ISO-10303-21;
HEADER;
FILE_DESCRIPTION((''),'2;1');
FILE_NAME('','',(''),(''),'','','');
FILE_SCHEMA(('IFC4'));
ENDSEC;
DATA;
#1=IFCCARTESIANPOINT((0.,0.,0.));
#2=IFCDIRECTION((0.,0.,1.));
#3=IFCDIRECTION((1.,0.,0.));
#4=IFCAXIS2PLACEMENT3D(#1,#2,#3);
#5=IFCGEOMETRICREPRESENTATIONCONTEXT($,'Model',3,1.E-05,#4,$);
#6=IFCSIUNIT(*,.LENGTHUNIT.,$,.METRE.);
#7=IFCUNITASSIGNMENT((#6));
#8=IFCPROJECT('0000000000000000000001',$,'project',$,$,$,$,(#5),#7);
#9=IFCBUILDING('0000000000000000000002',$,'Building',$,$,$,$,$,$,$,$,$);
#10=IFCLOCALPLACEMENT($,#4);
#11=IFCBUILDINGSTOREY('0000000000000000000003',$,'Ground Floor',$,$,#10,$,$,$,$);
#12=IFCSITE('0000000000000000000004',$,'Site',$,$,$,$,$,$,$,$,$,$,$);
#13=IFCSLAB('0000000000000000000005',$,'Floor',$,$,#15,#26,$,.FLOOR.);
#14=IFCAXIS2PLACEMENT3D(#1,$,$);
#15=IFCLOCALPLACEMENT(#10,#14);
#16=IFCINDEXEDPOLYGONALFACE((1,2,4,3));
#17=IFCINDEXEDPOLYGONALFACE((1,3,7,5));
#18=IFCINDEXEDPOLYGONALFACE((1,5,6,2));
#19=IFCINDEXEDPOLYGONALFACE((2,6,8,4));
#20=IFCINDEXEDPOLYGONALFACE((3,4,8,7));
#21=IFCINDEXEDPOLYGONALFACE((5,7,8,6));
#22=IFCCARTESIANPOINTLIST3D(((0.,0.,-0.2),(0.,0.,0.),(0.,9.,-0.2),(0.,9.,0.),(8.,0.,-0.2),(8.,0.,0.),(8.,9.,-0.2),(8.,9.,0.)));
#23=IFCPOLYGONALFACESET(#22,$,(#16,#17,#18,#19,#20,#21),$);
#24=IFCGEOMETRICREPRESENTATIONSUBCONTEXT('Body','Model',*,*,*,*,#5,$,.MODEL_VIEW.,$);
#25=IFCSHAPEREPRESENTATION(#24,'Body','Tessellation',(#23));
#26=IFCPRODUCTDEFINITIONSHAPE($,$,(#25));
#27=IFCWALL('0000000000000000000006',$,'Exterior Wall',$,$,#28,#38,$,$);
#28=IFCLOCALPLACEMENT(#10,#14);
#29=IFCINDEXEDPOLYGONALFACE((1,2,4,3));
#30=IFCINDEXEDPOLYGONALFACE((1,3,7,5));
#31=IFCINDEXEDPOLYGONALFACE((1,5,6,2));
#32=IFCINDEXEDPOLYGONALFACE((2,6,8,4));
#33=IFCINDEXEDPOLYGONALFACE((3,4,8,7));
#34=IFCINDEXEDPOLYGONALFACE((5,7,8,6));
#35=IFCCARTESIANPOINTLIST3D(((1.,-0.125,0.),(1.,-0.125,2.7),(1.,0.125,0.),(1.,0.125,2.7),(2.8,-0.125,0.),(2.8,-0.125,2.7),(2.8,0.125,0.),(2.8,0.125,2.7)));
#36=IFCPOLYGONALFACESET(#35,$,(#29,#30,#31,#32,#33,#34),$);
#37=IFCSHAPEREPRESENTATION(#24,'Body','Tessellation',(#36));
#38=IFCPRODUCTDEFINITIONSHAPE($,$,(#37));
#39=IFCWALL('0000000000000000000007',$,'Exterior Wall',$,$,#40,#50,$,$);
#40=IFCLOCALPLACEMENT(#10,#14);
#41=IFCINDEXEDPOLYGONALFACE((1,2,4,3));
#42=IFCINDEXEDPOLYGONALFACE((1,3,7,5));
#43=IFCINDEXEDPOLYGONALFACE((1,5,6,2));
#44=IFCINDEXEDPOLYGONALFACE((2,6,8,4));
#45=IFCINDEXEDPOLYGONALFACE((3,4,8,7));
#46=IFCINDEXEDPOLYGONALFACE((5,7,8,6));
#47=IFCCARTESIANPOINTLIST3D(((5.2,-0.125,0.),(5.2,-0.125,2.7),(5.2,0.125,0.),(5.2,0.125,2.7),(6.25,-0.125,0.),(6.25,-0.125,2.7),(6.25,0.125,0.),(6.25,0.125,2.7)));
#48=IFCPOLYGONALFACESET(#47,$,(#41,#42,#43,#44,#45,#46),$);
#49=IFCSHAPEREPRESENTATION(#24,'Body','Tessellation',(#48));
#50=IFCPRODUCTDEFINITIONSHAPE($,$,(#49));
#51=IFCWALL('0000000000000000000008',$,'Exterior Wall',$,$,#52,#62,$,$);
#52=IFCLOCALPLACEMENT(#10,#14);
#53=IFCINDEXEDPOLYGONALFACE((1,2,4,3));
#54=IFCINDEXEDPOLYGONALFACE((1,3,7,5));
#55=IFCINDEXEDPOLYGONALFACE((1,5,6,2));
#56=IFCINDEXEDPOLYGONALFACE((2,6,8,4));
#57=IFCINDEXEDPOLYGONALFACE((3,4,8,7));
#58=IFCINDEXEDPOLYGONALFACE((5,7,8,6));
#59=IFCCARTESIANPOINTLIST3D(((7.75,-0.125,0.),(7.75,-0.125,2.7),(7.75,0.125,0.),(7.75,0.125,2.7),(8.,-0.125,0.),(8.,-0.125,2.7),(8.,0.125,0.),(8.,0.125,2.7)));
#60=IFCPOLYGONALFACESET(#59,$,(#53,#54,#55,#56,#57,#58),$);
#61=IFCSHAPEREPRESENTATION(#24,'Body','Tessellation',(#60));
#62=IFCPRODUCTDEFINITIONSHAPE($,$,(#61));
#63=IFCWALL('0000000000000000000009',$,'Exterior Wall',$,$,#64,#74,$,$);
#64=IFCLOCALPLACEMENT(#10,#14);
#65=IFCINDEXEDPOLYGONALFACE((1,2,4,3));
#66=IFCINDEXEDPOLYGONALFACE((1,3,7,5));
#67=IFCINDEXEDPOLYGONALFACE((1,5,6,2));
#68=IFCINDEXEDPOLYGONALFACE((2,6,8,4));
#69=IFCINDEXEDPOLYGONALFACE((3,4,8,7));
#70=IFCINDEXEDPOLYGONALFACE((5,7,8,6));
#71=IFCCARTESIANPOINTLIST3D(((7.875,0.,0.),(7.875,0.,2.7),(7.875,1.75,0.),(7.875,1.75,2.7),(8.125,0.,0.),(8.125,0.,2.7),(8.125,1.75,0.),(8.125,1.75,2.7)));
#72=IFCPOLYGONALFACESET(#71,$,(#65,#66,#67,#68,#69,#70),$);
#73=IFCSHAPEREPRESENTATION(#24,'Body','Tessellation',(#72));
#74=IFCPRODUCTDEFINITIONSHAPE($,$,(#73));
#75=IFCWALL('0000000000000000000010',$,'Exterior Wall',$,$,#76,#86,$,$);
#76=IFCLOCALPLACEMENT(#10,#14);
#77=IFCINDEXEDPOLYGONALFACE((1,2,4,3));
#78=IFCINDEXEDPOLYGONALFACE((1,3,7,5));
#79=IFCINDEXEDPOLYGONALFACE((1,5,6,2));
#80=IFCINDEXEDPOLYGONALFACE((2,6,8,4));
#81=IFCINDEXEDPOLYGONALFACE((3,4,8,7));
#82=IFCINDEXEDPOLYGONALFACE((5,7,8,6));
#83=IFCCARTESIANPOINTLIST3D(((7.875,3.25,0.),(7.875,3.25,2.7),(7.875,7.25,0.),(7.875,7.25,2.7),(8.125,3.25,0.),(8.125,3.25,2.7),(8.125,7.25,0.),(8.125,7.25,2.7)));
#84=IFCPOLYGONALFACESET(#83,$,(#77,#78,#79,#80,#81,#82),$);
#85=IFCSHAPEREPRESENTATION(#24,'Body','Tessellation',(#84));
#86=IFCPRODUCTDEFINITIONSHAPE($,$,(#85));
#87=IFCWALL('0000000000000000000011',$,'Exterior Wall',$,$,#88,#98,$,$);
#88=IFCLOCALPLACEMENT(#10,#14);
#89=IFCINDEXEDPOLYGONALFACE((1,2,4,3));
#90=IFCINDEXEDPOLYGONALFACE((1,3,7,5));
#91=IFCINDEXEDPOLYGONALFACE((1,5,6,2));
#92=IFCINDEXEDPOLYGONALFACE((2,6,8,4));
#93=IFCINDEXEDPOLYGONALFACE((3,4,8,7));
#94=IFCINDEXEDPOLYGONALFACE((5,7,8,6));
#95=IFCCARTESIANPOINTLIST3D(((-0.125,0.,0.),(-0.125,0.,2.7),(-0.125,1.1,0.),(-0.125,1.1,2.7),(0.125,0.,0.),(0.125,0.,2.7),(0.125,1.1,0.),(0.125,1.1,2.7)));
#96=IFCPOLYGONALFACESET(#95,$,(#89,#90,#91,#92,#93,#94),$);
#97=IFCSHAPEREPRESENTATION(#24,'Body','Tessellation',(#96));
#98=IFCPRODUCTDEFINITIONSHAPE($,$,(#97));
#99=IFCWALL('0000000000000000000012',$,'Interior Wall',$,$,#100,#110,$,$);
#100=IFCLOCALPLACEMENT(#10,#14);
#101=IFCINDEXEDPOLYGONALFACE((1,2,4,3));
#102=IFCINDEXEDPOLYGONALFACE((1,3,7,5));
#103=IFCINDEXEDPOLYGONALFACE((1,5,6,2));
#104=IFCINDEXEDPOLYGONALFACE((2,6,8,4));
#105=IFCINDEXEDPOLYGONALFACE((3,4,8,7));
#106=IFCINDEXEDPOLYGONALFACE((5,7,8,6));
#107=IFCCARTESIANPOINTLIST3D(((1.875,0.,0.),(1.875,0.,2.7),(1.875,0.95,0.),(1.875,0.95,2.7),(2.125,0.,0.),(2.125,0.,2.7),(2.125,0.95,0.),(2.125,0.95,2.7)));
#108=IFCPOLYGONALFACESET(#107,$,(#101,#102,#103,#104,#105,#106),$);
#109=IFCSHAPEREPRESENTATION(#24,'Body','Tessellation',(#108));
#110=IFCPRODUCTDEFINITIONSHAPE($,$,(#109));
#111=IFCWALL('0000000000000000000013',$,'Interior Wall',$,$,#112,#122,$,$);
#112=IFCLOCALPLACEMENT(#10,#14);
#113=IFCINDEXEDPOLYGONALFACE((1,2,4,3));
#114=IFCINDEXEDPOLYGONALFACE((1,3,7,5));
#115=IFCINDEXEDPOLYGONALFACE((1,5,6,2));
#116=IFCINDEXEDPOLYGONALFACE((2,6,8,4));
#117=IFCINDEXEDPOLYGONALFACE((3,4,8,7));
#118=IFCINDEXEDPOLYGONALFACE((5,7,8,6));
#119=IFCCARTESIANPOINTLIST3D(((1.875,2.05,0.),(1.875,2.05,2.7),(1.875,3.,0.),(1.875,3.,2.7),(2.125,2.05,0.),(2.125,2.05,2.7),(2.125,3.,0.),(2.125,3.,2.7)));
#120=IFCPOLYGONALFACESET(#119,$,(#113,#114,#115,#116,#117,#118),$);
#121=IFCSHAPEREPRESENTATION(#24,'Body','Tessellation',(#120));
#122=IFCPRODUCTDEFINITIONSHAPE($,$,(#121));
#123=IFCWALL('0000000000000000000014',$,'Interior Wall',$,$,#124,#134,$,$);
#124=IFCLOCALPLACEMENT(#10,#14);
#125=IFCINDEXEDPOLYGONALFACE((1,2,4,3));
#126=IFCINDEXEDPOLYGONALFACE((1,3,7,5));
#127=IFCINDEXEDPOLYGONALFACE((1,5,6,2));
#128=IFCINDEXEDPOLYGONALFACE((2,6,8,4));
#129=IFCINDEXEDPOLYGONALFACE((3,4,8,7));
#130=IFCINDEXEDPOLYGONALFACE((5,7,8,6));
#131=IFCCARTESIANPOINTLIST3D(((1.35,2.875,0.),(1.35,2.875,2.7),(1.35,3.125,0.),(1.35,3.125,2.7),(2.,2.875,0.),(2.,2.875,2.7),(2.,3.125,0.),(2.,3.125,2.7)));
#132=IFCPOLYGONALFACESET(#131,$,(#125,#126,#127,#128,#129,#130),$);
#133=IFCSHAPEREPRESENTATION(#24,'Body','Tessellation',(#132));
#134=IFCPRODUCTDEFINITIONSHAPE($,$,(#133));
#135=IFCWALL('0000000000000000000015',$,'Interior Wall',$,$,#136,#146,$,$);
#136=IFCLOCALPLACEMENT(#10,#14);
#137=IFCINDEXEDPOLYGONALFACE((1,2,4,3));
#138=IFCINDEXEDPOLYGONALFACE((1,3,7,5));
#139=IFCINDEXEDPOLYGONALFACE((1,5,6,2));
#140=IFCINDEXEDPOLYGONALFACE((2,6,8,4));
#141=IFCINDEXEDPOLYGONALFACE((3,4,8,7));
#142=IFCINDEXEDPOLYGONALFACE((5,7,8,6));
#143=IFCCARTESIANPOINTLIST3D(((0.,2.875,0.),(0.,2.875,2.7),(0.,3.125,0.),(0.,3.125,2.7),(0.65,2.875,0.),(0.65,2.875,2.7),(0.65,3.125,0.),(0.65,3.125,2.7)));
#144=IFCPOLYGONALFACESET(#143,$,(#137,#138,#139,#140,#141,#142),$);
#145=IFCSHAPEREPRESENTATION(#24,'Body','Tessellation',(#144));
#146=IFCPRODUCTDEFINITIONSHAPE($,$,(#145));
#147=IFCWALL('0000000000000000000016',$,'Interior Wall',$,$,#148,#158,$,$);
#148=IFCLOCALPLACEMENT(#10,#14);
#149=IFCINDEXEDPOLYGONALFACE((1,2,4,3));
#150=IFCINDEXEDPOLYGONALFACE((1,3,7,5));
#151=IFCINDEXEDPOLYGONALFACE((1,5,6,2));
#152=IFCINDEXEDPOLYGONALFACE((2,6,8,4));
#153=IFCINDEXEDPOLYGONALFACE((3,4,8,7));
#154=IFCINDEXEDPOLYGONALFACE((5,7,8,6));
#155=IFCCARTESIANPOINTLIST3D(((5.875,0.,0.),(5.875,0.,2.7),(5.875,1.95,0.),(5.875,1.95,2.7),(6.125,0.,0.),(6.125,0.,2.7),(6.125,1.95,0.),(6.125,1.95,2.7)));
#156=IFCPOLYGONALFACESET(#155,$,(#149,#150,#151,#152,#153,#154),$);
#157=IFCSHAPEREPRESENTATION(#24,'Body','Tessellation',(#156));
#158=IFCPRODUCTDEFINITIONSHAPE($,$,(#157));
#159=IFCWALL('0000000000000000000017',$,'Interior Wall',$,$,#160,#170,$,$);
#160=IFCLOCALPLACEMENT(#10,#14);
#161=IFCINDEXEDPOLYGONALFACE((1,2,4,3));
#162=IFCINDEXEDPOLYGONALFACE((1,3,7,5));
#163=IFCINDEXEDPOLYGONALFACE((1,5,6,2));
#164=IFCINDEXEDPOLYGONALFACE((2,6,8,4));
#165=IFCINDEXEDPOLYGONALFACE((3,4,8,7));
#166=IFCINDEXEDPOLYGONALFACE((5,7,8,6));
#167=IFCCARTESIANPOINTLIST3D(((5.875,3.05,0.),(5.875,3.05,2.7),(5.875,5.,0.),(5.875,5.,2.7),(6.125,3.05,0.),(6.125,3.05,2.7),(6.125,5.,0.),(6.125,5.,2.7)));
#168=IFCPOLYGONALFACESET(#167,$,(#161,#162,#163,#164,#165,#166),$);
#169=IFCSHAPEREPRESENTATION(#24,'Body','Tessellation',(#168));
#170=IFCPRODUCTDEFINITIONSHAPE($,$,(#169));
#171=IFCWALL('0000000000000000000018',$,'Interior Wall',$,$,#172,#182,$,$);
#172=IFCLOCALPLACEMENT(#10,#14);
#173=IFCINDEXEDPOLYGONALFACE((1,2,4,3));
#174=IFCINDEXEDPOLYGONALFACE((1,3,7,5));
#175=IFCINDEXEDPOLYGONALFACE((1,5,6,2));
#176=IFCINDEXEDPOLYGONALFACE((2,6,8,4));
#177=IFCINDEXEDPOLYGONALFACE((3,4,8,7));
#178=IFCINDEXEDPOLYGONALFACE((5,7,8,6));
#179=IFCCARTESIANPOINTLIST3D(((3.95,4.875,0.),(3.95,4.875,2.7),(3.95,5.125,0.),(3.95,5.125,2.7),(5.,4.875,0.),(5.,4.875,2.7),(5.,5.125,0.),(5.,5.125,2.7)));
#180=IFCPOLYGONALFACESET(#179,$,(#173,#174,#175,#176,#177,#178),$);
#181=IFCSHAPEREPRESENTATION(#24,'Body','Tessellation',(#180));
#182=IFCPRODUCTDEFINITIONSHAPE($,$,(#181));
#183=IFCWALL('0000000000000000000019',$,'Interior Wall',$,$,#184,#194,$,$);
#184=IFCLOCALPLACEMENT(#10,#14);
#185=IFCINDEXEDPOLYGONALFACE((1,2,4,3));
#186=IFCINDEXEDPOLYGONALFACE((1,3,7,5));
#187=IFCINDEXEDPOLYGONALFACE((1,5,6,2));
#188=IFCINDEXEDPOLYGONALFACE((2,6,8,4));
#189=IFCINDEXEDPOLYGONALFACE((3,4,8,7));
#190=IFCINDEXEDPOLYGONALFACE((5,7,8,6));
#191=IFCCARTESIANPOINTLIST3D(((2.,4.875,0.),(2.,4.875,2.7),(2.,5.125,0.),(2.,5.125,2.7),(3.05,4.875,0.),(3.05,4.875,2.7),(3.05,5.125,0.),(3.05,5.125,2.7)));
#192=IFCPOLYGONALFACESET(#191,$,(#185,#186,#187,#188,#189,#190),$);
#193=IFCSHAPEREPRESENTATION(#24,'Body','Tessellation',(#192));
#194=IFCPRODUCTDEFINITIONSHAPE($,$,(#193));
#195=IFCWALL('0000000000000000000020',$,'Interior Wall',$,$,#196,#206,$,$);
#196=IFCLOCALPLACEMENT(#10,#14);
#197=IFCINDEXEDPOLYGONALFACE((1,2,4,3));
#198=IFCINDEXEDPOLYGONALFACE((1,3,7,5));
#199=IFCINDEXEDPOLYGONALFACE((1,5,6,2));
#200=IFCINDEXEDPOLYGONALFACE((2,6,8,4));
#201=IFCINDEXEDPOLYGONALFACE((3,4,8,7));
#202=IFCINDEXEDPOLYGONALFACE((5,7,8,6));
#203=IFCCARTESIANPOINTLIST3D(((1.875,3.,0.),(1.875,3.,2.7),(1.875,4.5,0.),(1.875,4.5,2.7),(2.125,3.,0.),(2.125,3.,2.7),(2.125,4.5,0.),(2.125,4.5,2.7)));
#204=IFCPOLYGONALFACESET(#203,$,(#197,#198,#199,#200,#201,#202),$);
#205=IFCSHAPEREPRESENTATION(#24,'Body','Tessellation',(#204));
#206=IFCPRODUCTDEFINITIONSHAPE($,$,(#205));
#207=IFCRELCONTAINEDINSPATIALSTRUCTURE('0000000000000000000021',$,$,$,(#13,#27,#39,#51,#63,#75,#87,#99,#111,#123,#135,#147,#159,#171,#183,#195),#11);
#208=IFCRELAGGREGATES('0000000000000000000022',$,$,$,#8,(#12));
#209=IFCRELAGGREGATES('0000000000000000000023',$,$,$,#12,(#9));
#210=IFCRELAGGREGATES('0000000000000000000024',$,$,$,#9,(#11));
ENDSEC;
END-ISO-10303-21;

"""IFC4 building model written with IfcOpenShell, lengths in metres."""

from ifc_helpers import new_model, si_unit, frame, origin_with_axes, place, context, subcontext, project, spatial, indexed_curve, outline, extrude, element, save


model = new_model("IFC4")

# Units and contexts
model_context = context("Model", 3, precision=1e-05, world=origin_with_axes())
body_context = subcontext(model_context, "Body", "Model", "MODEL_VIEW")
ifc_project = project(units=[si_unit("LENGTHUNIT", "METRE")], contexts=[model_context])

# Site, building, storey
site = spatial("IfcSite", under=ifc_project, Name="Site")
building = spatial("IfcBuilding", under=site, Name="Building")
storey_placement = place(None, origin_with_axes())
storey = spatial("IfcBuildingStorey", under=building, at=storey_placement, Name="Ground Floor")

# Slab
slab_placement = place(storey_placement, frame((0.0, 0.0, -0.2), z_axis=(0.0, 0.0, 1.0), x_axis=(1.0, 0.0, 0.0)))
element("IfcSlab", 1, at=slab_placement, inside=storey, Name="Floor", PredefinedType="FLOOR", context=body_context, shape_type="SweptSolid", body=[
    extrude(outline(indexed_curve([(0.0, 0.0), (8.0, 0.0), (8.0, 9.0), (0.0, 9.0)])), None, (0.0, 0.0, 1.0), 0.2),
])

# Walls
wall_1_placement = place(storey_placement, frame((1.0, 0.0, 0.0), z_axis=(0.0, 0.0, 1.0), x_axis=(1.0, 0.0, 0.0)))
element("IfcWall", 2, at=wall_1_placement, inside=storey, Name="Exterior Wall", context=body_context, shape_type="SweptSolid", body=[
    extrude(outline(indexed_curve([(0.0, 0.0), (0.0, 0.25), (1.8, 0.25), (1.8, 0.0), (0.0, 0.0)], self_intersect=False)), frame((0.0, -0.125, 0.0), z_axis=(0.0, 0.0, 1.0), x_axis=(1.0, 0.0, 0.0)), (0.0, 0.0, 1.0), 2.7),
])
wall_2_placement = place(storey_placement, frame((5.2, 0.0, 0.0), z_axis=(0.0, 0.0, 1.0), x_axis=(1.0, 0.0, 0.0)))
element("IfcWall", 3, at=wall_2_placement, inside=storey, Name="Exterior Wall", context=body_context, shape_type="SweptSolid", body=[
    extrude(outline(indexed_curve([(0.0, 0.0), (0.0, 0.25), (1.05, 0.25), (1.05, 0.0), (0.0, 0.0)], self_intersect=False)), frame((0.0, -0.125, 0.0), z_axis=(0.0, 0.0, 1.0), x_axis=(1.0, 0.0, 0.0)), (0.0, 0.0, 1.0), 2.7),
])
wall_3_placement = place(storey_placement, frame((7.75, 0.0, 0.0), z_axis=(0.0, 0.0, 1.0), x_axis=(1.0, 0.0, 0.0)))
element("IfcWall", 4, at=wall_3_placement, inside=storey, Name="Exterior Wall", context=body_context, shape_type="SweptSolid", body=[
    extrude(outline(indexed_curve([(0.0, 0.0), (0.0, 0.25), (0.25, 0.25), (0.25, 0.0), (0.0, 0.0)], self_intersect=False)), frame((0.0, -0.125, 0.0), z_axis=(0.0, 0.0, 1.0), x_axis=(1.0, 0.0, 0.0)), (0.0, 0.0, 1.0), 2.7),
])
wall_4_placement = place(storey_placement, frame((8.0, 0.0, 0.0), z_axis=(0.0, 0.0, 1.0), x_axis=(0.0, 1.0, 0.0)))
element("IfcWall", 5, at=wall_4_placement, inside=storey, Name="Exterior Wall", context=body_context, shape_type="SweptSolid", body=[
    extrude(outline(indexed_curve([(0.0, 0.0), (0.0, 0.25), (1.75, 0.25), (1.75, 0.0), (0.0, 0.0)], self_intersect=False)), frame((0.0, -0.125, 0.0), z_axis=(0.0, 0.0, 1.0), x_axis=(1.0, 0.0, 0.0)), (0.0, 0.0, 1.0), 2.7),
])
wall_5_placement = place(storey_placement, frame((8.0, 3.25, 0.0), z_axis=(0.0, 0.0, 1.0), x_axis=(0.0, 1.0, 0.0)))
element("IfcWall", 6, at=wall_5_placement, inside=storey, Name="Exterior Wall", context=body_context, shape_type="SweptSolid", body=[
    extrude(outline(indexed_curve([(0.0, 0.0), (0.0, 0.25), (4.0, 0.25), (4.0, 0.0), (0.0, 0.0)], self_intersect=False)), frame((0.0, -0.125, 0.0), z_axis=(0.0, 0.0, 1.0), x_axis=(1.0, 0.0, 0.0)), (0.0, 0.0, 1.0), 2.7),
])
wall_6_placement = place(storey_placement, frame((0.0, 1.1, 0.0), z_axis=(0.0, 0.0, 1.0), x_axis=(0.0, -1.0, 0.0)))
element("IfcWall", 7, at=wall_6_placement, inside=storey, Name="Exterior Wall", context=body_context, shape_type="SweptSolid", body=[
    extrude(outline(indexed_curve([(0.0, 0.0), (0.0, 0.25), (1.1, 0.25), (1.1, 0.0), (0.0, 0.0)], self_intersect=False)), frame((0.0, -0.125, 0.0), z_axis=(0.0, 0.0, 1.0), x_axis=(1.0, 0.0, 0.0)), (0.0, 0.0, 1.0), 2.7),
])
wall_7_placement = place(storey_placement, frame((2.0, 0.0, 0.0), z_axis=(0.0, 0.0, 1.0), x_axis=(0.0, 1.0, 0.0)))
element("IfcWall", 8, at=wall_7_placement, inside=storey, Name="Interior Wall", context=body_context, shape_type="SweptSolid", body=[
    extrude(outline(indexed_curve([(0.0, 0.0), (0.0, 0.25), (0.95, 0.25), (0.95, 0.0), (0.0, 0.0)], self_intersect=False)), frame((0.0, -0.125, 0.0), z_axis=(0.0, 0.0, 1.0), x_axis=(1.0, 0.0, 0.0)), (0.0, 0.0, 1.0), 2.7),
])
wall_8_placement = place(storey_placement, frame((2.0, 2.05, 0.0), z_axis=(0.0, 0.0, 1.0), x_axis=(0.0, 1.0, 0.0)))
element("IfcWall", 9, at=wall_8_placement, inside=storey, Name="Interior Wall", context=body_context, shape_type="SweptSolid", body=[
    extrude(outline(indexed_curve([(0.0, 0.0), (0.0, 0.25), (0.95, 0.25), (0.95, 0.0), (0.0, 0.0)], self_intersect=False)), frame((0.0, -0.125, 0.0), z_axis=(0.0, 0.0, 1.0), x_axis=(1.0, 0.0, 0.0)), (0.0, 0.0, 1.0), 2.7),
])
for number, where, z_axis, x_axis, name in (
    (10, (2.0, 3.0, 0.0), (0.0, 0.0, 1.0), (-1.0, 0.0, 0.0), "Interior Wall"),
    (11, (0.65, 3.0, 0.0), (0.0, 0.0, 1.0), (-1.0, 0.0, 0.0), "Interior Wall"),
):
    element("IfcWall", number, at=place(storey_placement, frame(where, z_axis=z_axis, x_axis=x_axis)), inside=storey, Name=name, context=body_context, shape_type="SweptSolid", body=[
        extrude(outline(indexed_curve([(0.0, 0.0), (0.0, 0.25), (0.65, 0.25), (0.65, 0.0), (0.0, 0.0)], self_intersect=False)), frame((0.0, -0.125, 0.0), z_axis=(0.0, 0.0, 1.0), x_axis=(1.0, 0.0, 0.0)), (0.0, 0.0, 1.0), 2.7),
    ])
wall_9_placement = place(storey_placement, frame((6.0, 0.0, 0.0), z_axis=(0.0, 0.0, 1.0), x_axis=(0.0, 1.0, 0.0)))
element("IfcWall", 12, at=wall_9_placement, inside=storey, Name="Interior Wall", context=body_context, shape_type="SweptSolid", body=[
    extrude(outline(indexed_curve([(0.0, 0.0), (0.0, 0.25), (1.95, 0.25), (1.95, 0.0), (0.0, 0.0)], self_intersect=False)), frame((0.0, -0.125, 0.0), z_axis=(0.0, 0.0, 1.0), x_axis=(1.0, 0.0, 0.0)), (0.0, 0.0, 1.0), 2.7),
])
wall_10_placement = place(storey_placement, frame((6.0, 3.05, 0.0), z_axis=(0.0, 0.0, 1.0), x_axis=(0.0, 1.0, 0.0)))
element("IfcWall", 13, at=wall_10_placement, inside=storey, Name="Interior Wall", context=body_context, shape_type="SweptSolid", body=[
    extrude(outline(indexed_curve([(0.0, 0.0), (0.0, 0.25), (1.95, 0.25), (1.95, 0.0), (0.0, 0.0)], self_intersect=False)), frame((0.0, -0.125, 0.0), z_axis=(0.0, 0.0, 1.0), x_axis=(1.0, 0.0, 0.0)), (0.0, 0.0, 1.0), 2.7),
])
for number, where, z_axis, x_axis, name in (
    (14, (5.0, 5.0, 0.0), (0.0, 0.0, 1.0), (-1.0, 0.0, 0.0), "Interior Wall"),
    (15, (3.05, 5.0, 0.0), (0.0, 0.0, 1.0), (-1.0, 0.0, 0.0), "Interior Wall"),
):
    element("IfcWall", number, at=place(storey_placement, frame(where, z_axis=z_axis, x_axis=x_axis)), inside=storey, Name=name, context=body_context, shape_type="SweptSolid", body=[
        extrude(outline(indexed_curve([(0.0, 0.0), (0.0, 0.25), (1.05, 0.25), (1.05, 0.0), (0.0, 0.0)], self_intersect=False)), frame((0.0, -0.125, 0.0), z_axis=(0.0, 0.0, 1.0), x_axis=(1.0, 0.0, 0.0)), (0.0, 0.0, 1.0), 2.7),
    ])
wall_11_placement = place(storey_placement, frame((2.0, 4.5, 0.0), z_axis=(0.0, 0.0, 1.0), x_axis=(0.0, -1.0, 0.0)))
element("IfcWall", 16, at=wall_11_placement, inside=storey, Name="Interior Wall", context=body_context, shape_type="SweptSolid", body=[
    extrude(outline(indexed_curve([(0.0, 0.0), (0.0, 0.25), (1.5, 0.25), (1.5, 0.0), (0.0, 0.0)], self_intersect=False)), frame((0.0, -0.125, 0.0), z_axis=(0.0, 0.0, 1.0), x_axis=(1.0, 0.0, 0.0)), (0.0, 0.0, 1.0), 2.7),
])

save(model, "model.ifc")
